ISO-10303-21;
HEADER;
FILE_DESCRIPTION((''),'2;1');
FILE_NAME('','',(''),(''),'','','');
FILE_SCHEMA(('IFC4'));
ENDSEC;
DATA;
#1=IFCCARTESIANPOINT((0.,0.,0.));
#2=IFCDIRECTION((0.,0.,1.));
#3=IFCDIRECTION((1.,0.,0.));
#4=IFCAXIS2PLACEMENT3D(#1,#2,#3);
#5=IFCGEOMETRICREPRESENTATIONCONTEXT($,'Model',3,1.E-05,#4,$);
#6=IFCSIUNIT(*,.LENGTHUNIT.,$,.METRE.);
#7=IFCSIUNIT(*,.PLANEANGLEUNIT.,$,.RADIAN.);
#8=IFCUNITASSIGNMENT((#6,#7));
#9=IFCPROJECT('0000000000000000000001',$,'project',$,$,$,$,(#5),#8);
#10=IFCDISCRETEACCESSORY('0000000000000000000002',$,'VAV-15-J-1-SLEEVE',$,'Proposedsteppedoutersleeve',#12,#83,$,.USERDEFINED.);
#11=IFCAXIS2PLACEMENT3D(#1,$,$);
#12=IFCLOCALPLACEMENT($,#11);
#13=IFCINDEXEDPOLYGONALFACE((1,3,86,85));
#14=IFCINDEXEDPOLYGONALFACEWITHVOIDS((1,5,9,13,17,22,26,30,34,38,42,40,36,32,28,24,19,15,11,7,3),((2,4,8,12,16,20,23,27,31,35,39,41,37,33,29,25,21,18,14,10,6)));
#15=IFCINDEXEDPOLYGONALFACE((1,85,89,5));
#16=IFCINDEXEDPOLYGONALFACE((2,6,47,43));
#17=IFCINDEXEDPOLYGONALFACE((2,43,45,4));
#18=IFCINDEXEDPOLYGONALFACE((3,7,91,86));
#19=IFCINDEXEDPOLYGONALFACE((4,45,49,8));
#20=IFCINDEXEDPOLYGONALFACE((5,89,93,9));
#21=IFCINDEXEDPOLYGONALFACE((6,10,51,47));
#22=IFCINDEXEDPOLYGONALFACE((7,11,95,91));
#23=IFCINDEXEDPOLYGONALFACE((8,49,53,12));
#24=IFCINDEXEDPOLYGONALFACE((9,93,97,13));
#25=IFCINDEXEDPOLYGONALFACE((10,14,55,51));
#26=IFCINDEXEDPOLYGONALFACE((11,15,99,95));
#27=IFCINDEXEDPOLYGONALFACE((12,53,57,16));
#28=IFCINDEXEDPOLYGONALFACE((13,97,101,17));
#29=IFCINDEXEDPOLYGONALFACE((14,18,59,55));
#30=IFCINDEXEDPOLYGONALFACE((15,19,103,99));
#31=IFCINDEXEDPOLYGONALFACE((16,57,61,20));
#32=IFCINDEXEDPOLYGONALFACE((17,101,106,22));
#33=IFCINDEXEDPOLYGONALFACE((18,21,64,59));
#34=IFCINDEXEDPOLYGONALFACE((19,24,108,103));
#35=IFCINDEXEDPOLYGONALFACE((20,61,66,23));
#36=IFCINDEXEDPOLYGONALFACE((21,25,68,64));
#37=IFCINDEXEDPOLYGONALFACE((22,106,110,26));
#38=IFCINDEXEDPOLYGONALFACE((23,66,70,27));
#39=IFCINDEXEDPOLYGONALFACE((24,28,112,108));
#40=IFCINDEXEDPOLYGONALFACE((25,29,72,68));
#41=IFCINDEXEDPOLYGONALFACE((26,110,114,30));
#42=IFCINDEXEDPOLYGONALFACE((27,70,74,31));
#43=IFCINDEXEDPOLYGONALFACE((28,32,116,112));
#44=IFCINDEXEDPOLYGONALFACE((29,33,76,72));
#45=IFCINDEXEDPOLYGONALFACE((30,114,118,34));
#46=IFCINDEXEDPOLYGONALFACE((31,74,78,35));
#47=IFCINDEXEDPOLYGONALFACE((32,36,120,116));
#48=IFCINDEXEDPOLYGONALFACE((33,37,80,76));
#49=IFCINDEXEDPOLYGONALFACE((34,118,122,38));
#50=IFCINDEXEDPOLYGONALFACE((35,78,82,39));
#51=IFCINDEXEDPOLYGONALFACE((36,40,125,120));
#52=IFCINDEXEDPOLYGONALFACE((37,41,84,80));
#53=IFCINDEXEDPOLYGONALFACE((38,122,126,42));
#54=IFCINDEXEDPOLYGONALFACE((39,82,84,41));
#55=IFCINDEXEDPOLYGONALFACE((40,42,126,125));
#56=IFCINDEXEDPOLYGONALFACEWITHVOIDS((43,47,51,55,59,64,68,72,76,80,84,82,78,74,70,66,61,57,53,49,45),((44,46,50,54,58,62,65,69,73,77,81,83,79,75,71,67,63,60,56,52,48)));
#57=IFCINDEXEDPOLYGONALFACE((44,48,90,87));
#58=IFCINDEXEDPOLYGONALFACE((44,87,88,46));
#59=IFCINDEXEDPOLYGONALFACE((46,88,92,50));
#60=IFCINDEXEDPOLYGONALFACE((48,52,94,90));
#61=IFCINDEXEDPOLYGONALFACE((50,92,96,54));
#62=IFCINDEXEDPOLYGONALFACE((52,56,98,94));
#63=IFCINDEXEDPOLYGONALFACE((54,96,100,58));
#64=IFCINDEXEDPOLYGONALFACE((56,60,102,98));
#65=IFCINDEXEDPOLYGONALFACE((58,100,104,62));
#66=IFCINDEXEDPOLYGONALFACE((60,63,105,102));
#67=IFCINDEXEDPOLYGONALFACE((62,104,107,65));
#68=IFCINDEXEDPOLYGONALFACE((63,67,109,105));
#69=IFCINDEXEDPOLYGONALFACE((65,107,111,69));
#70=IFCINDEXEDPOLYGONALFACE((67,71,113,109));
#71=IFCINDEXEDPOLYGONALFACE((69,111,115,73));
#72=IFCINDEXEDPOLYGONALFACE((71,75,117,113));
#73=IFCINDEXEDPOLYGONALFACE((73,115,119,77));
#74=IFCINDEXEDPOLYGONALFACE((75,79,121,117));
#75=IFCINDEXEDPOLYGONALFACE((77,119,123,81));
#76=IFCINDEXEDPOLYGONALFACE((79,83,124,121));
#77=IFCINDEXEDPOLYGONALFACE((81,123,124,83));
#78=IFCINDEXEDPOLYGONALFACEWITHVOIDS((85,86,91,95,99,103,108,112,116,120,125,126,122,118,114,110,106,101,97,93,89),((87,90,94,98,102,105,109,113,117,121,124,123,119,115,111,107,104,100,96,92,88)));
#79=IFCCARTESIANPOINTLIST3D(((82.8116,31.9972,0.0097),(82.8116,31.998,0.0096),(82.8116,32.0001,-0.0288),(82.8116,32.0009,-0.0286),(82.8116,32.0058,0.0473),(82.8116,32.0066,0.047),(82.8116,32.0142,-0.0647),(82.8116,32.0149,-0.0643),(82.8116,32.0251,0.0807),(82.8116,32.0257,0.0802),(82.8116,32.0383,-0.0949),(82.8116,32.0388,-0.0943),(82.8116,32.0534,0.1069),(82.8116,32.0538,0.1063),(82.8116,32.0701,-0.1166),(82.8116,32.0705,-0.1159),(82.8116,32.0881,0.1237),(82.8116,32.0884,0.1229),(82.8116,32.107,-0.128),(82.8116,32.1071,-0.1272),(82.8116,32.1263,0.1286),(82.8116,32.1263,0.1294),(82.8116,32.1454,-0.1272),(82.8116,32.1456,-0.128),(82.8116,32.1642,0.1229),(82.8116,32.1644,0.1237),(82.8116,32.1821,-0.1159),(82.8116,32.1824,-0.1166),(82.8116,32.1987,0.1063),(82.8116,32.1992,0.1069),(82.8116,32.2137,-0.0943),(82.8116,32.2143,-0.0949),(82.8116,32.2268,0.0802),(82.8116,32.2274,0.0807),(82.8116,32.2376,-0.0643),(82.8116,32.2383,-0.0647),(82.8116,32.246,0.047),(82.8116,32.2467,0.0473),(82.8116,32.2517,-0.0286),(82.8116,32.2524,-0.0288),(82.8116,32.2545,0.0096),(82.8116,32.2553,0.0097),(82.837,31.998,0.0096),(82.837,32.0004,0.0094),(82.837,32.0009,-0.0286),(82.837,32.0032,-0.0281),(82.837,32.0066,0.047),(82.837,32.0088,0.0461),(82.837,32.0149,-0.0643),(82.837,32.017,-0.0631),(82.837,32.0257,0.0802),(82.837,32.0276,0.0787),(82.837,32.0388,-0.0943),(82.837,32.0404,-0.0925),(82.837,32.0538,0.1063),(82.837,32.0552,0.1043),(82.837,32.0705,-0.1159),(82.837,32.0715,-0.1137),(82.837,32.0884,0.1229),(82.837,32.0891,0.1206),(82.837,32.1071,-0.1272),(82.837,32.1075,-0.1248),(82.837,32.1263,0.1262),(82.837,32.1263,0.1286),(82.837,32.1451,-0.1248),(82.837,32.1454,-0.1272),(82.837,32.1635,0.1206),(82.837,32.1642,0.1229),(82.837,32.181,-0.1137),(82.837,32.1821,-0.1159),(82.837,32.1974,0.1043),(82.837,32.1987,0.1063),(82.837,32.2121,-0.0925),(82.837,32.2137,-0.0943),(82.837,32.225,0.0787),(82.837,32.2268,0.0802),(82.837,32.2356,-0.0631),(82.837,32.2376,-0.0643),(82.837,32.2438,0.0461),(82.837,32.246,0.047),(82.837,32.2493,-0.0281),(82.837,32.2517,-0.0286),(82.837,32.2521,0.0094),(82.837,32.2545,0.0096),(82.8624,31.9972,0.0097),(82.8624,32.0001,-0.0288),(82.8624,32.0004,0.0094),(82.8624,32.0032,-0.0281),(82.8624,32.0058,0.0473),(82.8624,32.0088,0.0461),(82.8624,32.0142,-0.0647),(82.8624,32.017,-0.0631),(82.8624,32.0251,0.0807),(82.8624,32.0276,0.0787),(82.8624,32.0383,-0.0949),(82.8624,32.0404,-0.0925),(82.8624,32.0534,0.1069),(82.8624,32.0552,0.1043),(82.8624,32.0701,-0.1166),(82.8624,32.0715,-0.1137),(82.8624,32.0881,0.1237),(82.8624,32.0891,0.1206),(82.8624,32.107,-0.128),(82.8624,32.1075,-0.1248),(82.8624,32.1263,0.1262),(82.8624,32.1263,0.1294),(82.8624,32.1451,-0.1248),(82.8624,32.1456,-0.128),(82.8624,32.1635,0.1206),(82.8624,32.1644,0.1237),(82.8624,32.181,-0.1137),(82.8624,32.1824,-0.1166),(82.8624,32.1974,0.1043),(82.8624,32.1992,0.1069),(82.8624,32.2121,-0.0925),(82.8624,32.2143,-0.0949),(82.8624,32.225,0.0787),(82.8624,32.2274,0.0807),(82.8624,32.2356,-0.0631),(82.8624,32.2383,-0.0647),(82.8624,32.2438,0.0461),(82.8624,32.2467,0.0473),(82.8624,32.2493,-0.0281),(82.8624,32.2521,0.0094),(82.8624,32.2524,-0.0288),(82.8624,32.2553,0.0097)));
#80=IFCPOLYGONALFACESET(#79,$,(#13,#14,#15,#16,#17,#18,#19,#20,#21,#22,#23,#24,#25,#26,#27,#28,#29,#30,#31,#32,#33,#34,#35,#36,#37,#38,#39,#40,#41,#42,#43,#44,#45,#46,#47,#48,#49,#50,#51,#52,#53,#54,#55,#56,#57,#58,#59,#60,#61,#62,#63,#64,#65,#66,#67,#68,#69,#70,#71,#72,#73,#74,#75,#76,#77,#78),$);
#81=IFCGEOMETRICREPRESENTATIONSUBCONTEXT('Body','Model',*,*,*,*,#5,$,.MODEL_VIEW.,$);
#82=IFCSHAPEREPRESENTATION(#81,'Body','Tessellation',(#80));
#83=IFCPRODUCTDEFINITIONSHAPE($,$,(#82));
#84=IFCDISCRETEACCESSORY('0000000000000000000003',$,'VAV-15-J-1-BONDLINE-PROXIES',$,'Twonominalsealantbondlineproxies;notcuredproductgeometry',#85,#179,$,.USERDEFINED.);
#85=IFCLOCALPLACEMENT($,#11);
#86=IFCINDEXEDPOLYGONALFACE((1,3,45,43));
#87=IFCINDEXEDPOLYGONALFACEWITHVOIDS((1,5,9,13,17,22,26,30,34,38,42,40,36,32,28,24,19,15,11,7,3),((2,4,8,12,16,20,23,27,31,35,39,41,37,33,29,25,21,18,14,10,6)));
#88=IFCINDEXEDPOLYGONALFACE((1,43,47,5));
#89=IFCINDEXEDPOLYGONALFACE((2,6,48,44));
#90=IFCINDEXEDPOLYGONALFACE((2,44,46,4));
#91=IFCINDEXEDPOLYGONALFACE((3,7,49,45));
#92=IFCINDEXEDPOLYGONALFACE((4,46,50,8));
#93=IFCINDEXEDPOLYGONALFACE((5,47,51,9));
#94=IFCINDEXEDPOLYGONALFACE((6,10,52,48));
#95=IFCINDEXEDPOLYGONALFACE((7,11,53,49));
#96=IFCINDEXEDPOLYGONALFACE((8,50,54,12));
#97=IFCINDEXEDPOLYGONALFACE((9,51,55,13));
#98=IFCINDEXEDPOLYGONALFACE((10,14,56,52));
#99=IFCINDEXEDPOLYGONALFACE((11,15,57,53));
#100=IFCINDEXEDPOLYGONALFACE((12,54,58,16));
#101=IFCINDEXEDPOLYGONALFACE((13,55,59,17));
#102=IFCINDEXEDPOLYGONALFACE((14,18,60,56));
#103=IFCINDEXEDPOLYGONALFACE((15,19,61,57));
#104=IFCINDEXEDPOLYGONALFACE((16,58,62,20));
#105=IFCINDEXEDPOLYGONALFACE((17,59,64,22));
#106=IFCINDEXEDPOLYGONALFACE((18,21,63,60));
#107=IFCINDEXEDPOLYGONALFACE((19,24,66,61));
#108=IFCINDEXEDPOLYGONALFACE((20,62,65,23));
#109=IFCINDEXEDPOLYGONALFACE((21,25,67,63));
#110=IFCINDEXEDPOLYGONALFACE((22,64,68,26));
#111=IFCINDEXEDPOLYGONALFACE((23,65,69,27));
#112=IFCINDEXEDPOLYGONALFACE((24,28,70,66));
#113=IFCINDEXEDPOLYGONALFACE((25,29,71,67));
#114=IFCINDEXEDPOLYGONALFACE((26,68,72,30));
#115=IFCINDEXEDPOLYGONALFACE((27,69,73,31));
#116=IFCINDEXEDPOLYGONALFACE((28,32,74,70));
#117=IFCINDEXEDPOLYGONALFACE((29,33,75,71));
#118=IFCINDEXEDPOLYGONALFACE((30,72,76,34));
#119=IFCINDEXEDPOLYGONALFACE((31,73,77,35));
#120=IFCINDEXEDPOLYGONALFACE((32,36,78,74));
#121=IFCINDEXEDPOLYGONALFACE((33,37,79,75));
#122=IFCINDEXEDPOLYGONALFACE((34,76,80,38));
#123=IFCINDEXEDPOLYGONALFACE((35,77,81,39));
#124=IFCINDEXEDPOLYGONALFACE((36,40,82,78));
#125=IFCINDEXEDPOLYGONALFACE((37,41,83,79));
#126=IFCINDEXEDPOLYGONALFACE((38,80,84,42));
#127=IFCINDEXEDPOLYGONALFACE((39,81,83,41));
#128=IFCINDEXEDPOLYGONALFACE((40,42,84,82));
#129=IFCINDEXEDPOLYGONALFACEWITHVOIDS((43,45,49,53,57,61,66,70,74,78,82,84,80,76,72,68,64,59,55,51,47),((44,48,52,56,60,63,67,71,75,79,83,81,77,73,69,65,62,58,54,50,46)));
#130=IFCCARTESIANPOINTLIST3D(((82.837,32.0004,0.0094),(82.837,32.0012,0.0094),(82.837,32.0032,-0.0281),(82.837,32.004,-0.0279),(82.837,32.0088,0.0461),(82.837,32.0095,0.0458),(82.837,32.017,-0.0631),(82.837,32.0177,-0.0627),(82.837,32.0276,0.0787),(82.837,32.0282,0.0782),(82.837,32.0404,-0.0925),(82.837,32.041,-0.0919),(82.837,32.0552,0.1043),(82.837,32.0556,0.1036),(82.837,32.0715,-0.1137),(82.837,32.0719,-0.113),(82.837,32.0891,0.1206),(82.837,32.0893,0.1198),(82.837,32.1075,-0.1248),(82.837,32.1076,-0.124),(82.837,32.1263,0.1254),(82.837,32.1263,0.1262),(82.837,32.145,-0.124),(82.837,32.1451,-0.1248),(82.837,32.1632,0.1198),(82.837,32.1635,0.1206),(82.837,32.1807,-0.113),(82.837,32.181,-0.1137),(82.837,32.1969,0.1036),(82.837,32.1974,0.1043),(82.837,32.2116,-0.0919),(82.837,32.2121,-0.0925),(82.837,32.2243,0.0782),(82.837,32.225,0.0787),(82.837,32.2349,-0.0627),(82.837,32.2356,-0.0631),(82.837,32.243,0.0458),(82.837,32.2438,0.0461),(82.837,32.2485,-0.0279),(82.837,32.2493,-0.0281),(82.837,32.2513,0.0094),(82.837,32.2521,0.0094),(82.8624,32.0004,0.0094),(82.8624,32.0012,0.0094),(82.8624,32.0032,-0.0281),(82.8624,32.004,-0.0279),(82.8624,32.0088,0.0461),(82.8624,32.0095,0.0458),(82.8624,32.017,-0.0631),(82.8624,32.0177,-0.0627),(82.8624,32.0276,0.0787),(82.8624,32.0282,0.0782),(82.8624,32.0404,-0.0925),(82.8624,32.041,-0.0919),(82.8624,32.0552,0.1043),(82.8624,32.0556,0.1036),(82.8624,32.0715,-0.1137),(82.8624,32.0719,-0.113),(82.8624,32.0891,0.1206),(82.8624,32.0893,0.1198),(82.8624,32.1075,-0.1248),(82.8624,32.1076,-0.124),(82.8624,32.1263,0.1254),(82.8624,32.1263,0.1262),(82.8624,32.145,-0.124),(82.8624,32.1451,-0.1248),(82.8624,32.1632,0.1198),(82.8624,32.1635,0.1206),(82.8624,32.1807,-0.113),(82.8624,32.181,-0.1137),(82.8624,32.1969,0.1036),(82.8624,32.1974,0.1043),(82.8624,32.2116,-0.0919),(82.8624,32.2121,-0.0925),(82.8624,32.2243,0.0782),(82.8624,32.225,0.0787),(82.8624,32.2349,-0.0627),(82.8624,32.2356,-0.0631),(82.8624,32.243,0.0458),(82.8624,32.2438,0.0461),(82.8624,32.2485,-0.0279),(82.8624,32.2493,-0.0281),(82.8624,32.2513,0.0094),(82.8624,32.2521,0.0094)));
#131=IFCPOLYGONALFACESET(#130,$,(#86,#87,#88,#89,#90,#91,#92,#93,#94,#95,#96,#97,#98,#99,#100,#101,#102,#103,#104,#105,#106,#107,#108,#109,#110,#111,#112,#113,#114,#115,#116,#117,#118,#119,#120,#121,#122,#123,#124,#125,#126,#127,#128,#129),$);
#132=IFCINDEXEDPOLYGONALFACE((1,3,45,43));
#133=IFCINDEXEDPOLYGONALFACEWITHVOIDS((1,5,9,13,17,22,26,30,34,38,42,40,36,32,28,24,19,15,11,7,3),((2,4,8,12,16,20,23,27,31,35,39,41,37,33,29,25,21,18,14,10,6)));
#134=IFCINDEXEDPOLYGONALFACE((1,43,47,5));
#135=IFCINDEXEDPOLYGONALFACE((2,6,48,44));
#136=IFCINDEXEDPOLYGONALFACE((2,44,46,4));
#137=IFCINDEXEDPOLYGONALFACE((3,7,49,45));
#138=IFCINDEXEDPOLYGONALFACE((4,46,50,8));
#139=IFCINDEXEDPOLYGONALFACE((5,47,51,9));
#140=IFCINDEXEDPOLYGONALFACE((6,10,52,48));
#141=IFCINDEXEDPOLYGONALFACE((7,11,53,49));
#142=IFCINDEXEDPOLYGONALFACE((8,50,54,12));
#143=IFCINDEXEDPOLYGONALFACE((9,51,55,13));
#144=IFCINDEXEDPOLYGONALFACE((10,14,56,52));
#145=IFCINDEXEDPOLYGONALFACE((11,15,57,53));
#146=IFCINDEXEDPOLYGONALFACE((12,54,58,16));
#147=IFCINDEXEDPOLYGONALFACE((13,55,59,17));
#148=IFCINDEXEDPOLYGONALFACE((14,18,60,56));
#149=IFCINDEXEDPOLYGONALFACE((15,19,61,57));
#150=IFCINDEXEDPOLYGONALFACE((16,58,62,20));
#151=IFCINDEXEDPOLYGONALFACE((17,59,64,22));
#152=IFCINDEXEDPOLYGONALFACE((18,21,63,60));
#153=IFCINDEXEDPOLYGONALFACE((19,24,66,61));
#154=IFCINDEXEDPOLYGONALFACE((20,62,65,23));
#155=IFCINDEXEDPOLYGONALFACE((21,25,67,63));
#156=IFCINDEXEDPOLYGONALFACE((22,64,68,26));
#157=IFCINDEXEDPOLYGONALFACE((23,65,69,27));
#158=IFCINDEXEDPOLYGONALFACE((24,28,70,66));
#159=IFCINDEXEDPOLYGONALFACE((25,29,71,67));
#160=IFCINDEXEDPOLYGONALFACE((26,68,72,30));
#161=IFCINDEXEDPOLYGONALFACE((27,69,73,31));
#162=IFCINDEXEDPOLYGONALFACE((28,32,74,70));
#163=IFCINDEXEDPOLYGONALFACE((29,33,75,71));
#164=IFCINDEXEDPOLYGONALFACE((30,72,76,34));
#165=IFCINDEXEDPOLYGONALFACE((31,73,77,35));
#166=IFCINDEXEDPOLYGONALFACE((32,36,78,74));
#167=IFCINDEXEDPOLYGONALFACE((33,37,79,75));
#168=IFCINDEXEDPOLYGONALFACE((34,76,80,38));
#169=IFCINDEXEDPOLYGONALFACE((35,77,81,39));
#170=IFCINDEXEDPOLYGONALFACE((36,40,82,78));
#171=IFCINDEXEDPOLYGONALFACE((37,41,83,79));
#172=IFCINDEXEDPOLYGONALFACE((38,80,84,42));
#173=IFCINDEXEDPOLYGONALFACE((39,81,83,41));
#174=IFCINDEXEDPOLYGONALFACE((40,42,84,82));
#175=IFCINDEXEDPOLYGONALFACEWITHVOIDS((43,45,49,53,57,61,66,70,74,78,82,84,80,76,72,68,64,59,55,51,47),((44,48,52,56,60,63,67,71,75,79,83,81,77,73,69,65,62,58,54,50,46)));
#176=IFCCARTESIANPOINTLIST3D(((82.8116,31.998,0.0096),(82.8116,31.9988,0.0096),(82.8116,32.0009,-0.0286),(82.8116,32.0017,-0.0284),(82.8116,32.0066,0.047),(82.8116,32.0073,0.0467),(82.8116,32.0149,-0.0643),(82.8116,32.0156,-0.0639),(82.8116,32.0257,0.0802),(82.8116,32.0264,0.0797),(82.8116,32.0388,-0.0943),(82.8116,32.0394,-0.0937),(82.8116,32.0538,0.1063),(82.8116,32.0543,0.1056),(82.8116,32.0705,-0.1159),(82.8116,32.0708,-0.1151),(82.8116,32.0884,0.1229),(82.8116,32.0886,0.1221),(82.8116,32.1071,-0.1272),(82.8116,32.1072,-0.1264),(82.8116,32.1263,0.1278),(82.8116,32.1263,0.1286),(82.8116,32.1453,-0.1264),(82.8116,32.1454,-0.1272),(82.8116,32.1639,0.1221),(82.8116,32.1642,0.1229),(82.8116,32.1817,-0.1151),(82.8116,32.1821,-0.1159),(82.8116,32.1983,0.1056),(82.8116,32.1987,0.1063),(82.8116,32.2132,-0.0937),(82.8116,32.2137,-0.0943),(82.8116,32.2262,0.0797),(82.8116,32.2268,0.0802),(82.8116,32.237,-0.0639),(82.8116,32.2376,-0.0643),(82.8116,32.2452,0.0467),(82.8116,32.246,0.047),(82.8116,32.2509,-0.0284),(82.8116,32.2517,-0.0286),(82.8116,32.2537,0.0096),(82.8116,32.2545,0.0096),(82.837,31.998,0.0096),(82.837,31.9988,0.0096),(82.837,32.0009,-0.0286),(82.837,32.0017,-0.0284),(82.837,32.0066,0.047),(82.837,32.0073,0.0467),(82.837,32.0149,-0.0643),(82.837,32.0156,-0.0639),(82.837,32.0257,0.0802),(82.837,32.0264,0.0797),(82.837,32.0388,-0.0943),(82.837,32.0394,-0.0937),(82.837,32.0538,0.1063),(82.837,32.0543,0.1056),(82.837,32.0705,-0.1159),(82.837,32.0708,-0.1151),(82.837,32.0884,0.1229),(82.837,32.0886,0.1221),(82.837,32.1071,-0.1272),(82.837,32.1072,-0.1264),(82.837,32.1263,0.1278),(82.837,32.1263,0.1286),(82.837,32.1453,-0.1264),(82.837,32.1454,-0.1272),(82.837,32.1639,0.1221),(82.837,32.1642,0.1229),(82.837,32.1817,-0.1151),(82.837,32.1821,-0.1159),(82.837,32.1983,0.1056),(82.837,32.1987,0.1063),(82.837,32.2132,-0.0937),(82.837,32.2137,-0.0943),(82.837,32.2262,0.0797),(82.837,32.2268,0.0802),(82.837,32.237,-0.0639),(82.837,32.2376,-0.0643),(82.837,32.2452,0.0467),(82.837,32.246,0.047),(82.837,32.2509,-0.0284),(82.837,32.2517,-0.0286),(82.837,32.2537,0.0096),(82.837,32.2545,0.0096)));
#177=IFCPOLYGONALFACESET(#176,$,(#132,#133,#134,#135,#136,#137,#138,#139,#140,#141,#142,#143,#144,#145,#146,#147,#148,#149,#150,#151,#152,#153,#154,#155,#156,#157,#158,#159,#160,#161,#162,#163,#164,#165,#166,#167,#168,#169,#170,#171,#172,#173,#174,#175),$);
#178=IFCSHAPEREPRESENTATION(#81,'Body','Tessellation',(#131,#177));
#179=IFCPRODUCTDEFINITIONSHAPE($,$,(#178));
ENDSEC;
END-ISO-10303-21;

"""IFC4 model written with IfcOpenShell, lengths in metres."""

from ifc_helpers import new_model, entity, si_unit, frame, origin_with_axes, place, context, subcontext, project, element, save


model = new_model("IFC4")

# Units and contexts
model_context = context("Model", 3, precision=1e-05, world=origin_with_axes())
body_context = subcontext(model_context, "Body", "Model", "MODEL_VIEW")
ifc_project = project(units=[si_unit("LENGTHUNIT", "METRE"), si_unit("PLANEANGLEUNIT", "RADIAN")], contexts=[model_context])

# Discrete accessories
discrete_accessory_1_placement = place(None, frame((82.837, 32.1263, 0.0), z_axis=(0.0, -1.0, 0.0), x_axis=(0.0, 0.0, 1.0)))
element("IfcDiscreteAccessory", 1, at=discrete_accessory_1_placement, Name="VAV-15-J-1-SLEEVE", ObjectType="Proposedsteppedoutersleeve", PredefinedType="USERDEFINED", context=body_context, shape_type="SweptSolid", body=[
    entity("IfcRevolvedAreaSolid", entity("IfcArbitraryClosedProfileDef", "AREA", None, entity("IfcPolyline", [entity("IfcCartesianPoint", [0.1262, -0.0254]), entity("IfcCartesianPoint", [0.1294, -0.0254]), entity("IfcCartesianPoint", [0.1294, 0.0254]), entity("IfcCartesianPoint", [0.1286, 0.0254]), entity("IfcCartesianPoint", [0.1286, 0.0]), entity("IfcCartesianPoint", [0.1262, 0.0]), entity("IfcCartesianPoint", [0.1262, -0.0254])])), entity("IfcAxis2Placement3D", entity("IfcCartesianPoint", [0.0, 0.0, 0.0])), entity("IfcAxis1Placement", entity("IfcCartesianPoint", [0.0, 0.0, 0.0]), entity("IfcDirection", [0.0, 1.0, 0.0])), 6.283185),
])
discrete_accessory_2_placement = place(None, frame((82.837, 32.1263, 0.0), z_axis=(0.0, -1.0, 0.0), x_axis=(0.0, 0.0, 1.0)))
element("IfcDiscreteAccessory", 2, at=discrete_accessory_2_placement, Name="VAV-15-J-1-BONDLINE-PROXIES", ObjectType="Twonominalsealantbondlineproxies;notcuredproductgeometry", PredefinedType="USERDEFINED", context=body_context, shape_type="SweptSolid", body=[
    entity("IfcRevolvedAreaSolid", entity("IfcArbitraryClosedProfileDef", "AREA", None, entity("IfcPolyline", [entity("IfcCartesianPoint", [0.1254, -0.0254]), entity("IfcCartesianPoint", [0.1262, -0.0254]), entity("IfcCartesianPoint", [0.1262, 0.0]), entity("IfcCartesianPoint", [0.1254, 0.0]), entity("IfcCartesianPoint", [0.1254, -0.0254])])), entity("IfcAxis2Placement3D", entity("IfcCartesianPoint", [0.0, 0.0, 0.0])), entity("IfcAxis1Placement", entity("IfcCartesianPoint", [0.0, 0.0, 0.0]), entity("IfcDirection", [0.0, 1.0, 0.0])), 6.283185),
    entity("IfcRevolvedAreaSolid", entity("IfcArbitraryClosedProfileDef", "AREA", None, entity("IfcPolyline", [entity("IfcCartesianPoint", [0.1278, 0.0]), entity("IfcCartesianPoint", [0.1286, 0.0]), entity("IfcCartesianPoint", [0.1286, 0.0254]), entity("IfcCartesianPoint", [0.1278, 0.0254]), entity("IfcCartesianPoint", [0.1278, 0.0])])), entity("IfcAxis2Placement3D", entity("IfcCartesianPoint", [0.0, 0.0, 0.0])), entity("IfcAxis1Placement", entity("IfcCartesianPoint", [0.0, 0.0, 0.0]), entity("IfcDirection", [0.0, 1.0, 0.0])), 6.283185),
])

save(model, "model.ifc")
